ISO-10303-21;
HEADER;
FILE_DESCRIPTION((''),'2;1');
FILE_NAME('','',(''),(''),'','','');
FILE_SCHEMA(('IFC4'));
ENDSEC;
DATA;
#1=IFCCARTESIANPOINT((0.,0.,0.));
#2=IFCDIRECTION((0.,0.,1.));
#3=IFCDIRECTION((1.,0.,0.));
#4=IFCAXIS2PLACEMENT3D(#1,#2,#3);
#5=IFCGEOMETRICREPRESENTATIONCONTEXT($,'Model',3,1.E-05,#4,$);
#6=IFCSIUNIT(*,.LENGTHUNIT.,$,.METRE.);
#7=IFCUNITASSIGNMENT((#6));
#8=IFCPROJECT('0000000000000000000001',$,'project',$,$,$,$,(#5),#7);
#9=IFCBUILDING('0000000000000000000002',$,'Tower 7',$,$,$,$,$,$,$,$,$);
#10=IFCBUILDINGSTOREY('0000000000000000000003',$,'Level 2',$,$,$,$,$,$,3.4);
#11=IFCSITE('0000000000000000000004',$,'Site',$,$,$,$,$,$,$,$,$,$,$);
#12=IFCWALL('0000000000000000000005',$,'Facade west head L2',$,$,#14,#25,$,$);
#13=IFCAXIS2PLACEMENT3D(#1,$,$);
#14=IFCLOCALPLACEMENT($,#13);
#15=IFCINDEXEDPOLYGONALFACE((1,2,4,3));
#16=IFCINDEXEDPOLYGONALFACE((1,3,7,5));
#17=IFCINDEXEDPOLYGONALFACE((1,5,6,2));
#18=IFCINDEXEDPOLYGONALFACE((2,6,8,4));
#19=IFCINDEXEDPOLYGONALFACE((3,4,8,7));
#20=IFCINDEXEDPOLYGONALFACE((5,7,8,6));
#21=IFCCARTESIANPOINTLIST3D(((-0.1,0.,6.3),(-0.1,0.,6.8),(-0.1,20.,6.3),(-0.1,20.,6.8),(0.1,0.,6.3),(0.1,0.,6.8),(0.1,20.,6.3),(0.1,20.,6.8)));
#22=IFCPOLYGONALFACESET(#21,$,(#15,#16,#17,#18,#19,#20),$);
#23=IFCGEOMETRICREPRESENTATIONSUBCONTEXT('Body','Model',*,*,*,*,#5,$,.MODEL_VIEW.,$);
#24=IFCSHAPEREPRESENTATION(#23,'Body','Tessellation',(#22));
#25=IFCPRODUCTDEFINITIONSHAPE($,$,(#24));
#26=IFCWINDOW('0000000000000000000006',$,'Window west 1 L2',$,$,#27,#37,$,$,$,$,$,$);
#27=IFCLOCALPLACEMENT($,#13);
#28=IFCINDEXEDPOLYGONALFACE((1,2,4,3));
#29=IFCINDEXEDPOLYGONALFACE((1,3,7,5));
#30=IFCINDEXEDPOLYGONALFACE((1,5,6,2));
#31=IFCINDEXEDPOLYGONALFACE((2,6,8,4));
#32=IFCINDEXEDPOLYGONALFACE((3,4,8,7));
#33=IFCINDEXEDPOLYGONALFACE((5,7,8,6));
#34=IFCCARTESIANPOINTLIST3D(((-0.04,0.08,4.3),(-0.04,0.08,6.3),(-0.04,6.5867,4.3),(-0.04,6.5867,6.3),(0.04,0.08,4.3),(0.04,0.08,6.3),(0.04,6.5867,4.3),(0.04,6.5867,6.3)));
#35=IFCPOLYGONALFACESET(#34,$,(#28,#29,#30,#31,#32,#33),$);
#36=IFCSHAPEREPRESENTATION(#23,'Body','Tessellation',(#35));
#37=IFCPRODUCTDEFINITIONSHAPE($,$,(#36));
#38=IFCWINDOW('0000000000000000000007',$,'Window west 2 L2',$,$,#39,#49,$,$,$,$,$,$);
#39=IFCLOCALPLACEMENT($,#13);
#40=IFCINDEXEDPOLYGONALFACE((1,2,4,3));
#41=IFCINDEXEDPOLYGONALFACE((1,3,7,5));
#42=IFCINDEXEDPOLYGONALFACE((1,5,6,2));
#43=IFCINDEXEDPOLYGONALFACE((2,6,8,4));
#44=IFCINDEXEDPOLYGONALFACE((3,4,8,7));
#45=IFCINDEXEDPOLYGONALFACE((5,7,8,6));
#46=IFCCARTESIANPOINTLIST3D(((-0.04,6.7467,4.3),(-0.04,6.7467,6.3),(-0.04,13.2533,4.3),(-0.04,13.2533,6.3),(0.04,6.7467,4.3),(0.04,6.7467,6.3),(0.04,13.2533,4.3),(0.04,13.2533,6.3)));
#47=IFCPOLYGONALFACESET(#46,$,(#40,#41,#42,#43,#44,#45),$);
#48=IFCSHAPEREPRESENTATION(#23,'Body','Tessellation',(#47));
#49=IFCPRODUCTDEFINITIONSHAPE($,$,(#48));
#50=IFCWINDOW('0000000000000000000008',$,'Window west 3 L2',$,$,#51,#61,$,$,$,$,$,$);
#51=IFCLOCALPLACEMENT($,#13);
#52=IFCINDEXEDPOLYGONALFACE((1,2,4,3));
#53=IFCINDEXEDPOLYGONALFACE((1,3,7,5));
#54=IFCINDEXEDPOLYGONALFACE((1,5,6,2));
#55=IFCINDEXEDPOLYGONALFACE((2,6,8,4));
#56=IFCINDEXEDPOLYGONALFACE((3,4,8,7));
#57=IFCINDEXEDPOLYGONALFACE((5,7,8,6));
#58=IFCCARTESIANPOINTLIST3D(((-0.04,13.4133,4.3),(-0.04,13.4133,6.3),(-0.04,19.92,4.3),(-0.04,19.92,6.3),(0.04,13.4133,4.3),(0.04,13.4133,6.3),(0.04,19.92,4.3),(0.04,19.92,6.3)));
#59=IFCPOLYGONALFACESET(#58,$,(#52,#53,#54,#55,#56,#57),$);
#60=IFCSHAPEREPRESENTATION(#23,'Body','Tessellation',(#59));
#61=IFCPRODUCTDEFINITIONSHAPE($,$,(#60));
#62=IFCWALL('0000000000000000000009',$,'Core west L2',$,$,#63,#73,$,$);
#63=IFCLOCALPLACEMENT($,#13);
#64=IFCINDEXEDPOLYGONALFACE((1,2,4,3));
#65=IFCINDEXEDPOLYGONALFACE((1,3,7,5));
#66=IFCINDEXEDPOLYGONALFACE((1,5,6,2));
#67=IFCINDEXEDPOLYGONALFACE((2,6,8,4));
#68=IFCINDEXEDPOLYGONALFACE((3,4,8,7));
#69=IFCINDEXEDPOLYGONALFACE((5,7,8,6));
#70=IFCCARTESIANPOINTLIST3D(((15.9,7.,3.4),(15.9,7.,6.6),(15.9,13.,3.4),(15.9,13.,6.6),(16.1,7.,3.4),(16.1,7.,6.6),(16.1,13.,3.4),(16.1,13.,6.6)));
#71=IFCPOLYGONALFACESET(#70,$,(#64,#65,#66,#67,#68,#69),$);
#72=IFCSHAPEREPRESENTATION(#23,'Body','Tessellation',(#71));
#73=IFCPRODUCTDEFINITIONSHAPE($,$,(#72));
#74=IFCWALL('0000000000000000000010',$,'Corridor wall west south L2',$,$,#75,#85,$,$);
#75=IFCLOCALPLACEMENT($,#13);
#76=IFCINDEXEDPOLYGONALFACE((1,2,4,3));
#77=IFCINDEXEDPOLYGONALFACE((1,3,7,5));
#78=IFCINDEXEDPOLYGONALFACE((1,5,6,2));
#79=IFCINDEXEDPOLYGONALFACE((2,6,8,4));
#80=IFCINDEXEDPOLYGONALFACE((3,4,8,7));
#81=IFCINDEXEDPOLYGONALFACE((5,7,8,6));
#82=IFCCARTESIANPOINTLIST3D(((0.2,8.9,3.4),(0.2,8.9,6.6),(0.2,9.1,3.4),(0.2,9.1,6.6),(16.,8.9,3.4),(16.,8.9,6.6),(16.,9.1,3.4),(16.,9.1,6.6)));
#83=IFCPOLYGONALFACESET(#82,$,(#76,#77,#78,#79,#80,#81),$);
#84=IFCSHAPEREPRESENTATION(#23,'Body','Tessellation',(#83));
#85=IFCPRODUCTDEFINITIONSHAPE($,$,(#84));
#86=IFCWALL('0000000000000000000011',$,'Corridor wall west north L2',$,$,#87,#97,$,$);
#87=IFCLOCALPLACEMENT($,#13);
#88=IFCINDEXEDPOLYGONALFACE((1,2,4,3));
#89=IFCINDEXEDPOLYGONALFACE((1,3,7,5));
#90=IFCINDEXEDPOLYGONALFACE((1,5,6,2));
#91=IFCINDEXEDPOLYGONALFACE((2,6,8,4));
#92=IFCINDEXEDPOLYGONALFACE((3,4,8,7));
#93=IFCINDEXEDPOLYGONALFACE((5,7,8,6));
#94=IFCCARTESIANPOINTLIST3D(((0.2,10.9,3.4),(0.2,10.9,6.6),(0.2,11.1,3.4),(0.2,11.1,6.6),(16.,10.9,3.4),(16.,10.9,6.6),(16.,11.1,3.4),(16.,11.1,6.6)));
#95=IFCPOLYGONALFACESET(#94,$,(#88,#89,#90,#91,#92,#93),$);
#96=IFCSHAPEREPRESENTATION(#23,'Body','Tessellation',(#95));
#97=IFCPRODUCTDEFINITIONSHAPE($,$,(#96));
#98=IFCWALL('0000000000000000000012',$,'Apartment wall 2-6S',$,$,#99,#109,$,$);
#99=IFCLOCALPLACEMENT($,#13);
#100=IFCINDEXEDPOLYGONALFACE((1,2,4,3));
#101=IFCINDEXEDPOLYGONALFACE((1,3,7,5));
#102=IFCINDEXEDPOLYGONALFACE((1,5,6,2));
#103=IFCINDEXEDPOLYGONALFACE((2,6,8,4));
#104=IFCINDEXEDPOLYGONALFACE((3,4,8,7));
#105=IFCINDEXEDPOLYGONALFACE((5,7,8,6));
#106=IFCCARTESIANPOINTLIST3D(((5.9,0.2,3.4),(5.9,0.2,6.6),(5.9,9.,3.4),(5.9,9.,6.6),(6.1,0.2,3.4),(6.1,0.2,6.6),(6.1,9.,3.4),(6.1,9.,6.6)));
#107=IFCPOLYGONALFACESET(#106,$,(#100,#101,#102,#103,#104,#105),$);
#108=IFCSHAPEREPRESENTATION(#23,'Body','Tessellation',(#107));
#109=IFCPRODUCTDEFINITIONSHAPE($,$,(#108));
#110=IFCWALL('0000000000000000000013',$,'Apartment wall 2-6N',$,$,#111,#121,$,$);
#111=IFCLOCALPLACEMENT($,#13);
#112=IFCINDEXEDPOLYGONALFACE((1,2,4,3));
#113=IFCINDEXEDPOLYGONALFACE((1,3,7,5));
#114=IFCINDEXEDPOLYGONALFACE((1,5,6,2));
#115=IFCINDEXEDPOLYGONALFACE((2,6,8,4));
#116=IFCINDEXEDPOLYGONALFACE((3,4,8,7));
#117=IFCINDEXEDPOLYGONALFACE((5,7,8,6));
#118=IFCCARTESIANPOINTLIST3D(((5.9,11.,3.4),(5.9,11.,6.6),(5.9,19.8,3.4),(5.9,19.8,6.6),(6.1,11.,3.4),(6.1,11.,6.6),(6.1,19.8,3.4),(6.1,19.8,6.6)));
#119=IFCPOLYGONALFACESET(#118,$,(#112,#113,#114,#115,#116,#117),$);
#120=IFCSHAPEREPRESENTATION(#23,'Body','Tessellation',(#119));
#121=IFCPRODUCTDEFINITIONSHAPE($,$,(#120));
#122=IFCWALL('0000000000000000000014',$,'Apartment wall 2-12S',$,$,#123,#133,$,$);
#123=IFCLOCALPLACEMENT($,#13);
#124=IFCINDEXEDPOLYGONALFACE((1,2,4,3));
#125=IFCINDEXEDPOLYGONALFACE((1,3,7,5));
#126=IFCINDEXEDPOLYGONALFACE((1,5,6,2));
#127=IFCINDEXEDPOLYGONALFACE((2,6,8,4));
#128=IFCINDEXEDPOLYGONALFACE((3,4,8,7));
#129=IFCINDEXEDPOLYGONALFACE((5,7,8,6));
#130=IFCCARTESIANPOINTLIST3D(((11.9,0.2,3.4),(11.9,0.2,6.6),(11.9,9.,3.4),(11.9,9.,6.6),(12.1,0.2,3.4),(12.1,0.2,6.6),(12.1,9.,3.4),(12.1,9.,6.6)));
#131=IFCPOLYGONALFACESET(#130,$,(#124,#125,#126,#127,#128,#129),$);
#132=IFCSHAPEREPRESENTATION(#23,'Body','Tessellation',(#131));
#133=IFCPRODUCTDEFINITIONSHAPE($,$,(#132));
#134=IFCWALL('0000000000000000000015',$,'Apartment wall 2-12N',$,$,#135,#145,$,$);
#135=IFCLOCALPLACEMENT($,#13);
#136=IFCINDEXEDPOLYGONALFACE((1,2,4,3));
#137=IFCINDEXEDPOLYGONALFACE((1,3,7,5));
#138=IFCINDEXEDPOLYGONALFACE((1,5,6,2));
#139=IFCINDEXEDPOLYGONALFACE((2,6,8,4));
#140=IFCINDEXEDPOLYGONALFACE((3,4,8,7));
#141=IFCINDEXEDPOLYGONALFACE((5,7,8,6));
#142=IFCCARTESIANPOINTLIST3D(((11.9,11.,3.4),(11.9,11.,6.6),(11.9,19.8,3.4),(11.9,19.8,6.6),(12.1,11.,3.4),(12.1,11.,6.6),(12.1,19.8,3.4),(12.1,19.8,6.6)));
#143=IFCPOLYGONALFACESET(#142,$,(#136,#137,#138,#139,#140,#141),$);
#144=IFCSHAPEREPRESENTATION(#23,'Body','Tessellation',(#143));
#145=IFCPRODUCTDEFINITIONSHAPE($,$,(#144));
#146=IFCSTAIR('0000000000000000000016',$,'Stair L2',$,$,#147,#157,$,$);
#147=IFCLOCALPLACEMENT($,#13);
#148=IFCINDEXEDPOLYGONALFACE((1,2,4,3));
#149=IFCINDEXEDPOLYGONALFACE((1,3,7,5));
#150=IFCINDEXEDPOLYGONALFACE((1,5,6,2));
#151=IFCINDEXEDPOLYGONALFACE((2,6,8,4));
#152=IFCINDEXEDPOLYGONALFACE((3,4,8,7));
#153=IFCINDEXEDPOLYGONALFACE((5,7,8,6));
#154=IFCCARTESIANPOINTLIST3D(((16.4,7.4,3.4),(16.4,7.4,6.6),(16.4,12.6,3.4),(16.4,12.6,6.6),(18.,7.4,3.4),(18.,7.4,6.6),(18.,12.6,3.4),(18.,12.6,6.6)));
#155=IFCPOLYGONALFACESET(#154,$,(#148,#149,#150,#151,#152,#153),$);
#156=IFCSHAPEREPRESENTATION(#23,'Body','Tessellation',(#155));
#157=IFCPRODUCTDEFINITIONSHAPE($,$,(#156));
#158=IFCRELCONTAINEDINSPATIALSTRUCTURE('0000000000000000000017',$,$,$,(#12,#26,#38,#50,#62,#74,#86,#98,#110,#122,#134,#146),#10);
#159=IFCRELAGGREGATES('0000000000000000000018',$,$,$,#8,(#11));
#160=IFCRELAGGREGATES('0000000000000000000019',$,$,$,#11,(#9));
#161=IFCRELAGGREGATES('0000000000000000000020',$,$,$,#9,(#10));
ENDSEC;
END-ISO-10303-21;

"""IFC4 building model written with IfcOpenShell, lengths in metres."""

from ifc_helpers import new_model, si_unit, frame, origin, origin_with_axes, origin_2d, place, context, subcontext, project, spatial, rectangle, extrude, element, save


model = new_model("IFC4")

# Units and contexts
model_context = context("Model", 3, precision=1e-05, world=origin_with_axes())
body_context = subcontext(model_context, "Body", "Model", "MODEL_VIEW")
ifc_project = project(units=[si_unit("LENGTHUNIT", "METRE")], contexts=[model_context])

# Site, building, storey
site = spatial("IfcSite", under=ifc_project, Name="Site")
building = spatial("IfcBuilding", under=site, Name="Tower 7")
storey = spatial("IfcBuildingStorey", under=building, Name="Level 2", Elevation=3.4)

# Wall
wall_1_placement = place(None, frame((0.0, 10.0, 6.3), z_axis=(0.0, 0.0, 1.0), x_axis=(1.0, 0.0, 0.0)))
element("IfcWall", 1, at=wall_1_placement, inside=storey, Name="Facade west head L2", context=body_context, shape_type="SweptSolid", body=[
    extrude(rectangle(XDim=0.2, YDim=20.0, at=origin_2d()), origin(), (0.0, 0.0, 1.0), 0.5),
])

# Windows
for number, where, z_axis, x_axis, name in (
    (2, (0.0, 3.3333, 4.3), (0.0, 0.0, 1.0), (1.0, 0.0, 0.0), "Window west 1 L2"),
    (3, (0.0, 10.0, 4.3), (0.0, 0.0, 1.0), (1.0, 0.0, 0.0), "Window west 2 L2"),
):
    element("IfcWindow", number, at=place(None, frame(where, z_axis=z_axis, x_axis=x_axis)), inside=storey, Name=name, context=body_context, shape_type="SweptSolid", body=[
        extrude(rectangle(XDim=0.08, YDim=6.5067, at=origin_2d()), origin(), (0.0, 0.0, 1.0), 2.0),
    ])
window_1_placement = place(None, frame((0.0, 16.6667, 4.3), z_axis=(0.0, 0.0, 1.0), x_axis=(1.0, 0.0, 0.0)))
element("IfcWindow", 4, at=window_1_placement, inside=storey, Name="Window west 3 L2", context=body_context, shape_type="SweptSolid", body=[
    extrude(rectangle(XDim=0.08, YDim=6.5067, at=origin_2d()), origin(), (0.0, 0.0, 1.0), 2.0),
])

# Walls
wall_2_placement = place(None, frame((16.0, 10.0, 3.4), z_axis=(0.0, 0.0, 1.0), x_axis=(1.0, 0.0, 0.0)))
element("IfcWall", 5, at=wall_2_placement, inside=storey, Name="Core west L2", context=body_context, shape_type="SweptSolid", body=[
    extrude(rectangle(XDim=0.2, YDim=6.0, at=origin_2d()), origin(), (0.0, 0.0, 1.0), 3.2),
])
for number, where, z_axis, x_axis, name in (
    (6, (8.1, 9.0, 3.4), (0.0, 0.0, 1.0), (1.0, 0.0, 0.0), "Corridor wall west south L2"),
    (7, (8.1, 11.0, 3.4), (0.0, 0.0, 1.0), (1.0, 0.0, 0.0), "Corridor wall west north L2"),
):
    element("IfcWall", number, at=place(None, frame(where, z_axis=z_axis, x_axis=x_axis)), inside=storey, Name=name, context=body_context, shape_type="SweptSolid", body=[
        extrude(rectangle(XDim=15.8, YDim=0.2, at=origin_2d()), origin(), (0.0, 0.0, 1.0), 3.2),
    ])
for number, where, z_axis, x_axis, name in (
    (8, (6.0, 4.6, 3.4), (0.0, 0.0, 1.0), (1.0, 0.0, 0.0), "Apartment wall 2-6S"),
    (9, (6.0, 15.4, 3.4), (0.0, 0.0, 1.0), (1.0, 0.0, 0.0), "Apartment wall 2-6N"),
    (10, (12.0, 4.6, 3.4), (0.0, 0.0, 1.0), (1.0, 0.0, 0.0), "Apartment wall 2-12S"),
    (11, (12.0, 15.4, 3.4), (0.0, 0.0, 1.0), (1.0, 0.0, 0.0), "Apartment wall 2-12N"),
):
    element("IfcWall", number, at=place(None, frame(where, z_axis=z_axis, x_axis=x_axis)), inside=storey, Name=name, context=body_context, shape_type="SweptSolid", body=[
        extrude(rectangle(XDim=0.2, YDim=8.8, at=origin_2d()), origin(), (0.0, 0.0, 1.0), 3.2),
    ])

# Stair
stair_placement = place(None, frame((17.2, 10.0, 3.4), z_axis=(0.0, 0.0, 1.0), x_axis=(1.0, 0.0, 0.0)))
element("IfcStair", 12, at=stair_placement, inside=storey, Name="Stair L2", context=body_context, shape_type="SweptSolid", body=[
    extrude(rectangle(XDim=1.6, YDim=5.2, at=origin_2d()), origin(), (0.0, 0.0, 1.0), 3.2),
])

save(model, "model.ifc")
